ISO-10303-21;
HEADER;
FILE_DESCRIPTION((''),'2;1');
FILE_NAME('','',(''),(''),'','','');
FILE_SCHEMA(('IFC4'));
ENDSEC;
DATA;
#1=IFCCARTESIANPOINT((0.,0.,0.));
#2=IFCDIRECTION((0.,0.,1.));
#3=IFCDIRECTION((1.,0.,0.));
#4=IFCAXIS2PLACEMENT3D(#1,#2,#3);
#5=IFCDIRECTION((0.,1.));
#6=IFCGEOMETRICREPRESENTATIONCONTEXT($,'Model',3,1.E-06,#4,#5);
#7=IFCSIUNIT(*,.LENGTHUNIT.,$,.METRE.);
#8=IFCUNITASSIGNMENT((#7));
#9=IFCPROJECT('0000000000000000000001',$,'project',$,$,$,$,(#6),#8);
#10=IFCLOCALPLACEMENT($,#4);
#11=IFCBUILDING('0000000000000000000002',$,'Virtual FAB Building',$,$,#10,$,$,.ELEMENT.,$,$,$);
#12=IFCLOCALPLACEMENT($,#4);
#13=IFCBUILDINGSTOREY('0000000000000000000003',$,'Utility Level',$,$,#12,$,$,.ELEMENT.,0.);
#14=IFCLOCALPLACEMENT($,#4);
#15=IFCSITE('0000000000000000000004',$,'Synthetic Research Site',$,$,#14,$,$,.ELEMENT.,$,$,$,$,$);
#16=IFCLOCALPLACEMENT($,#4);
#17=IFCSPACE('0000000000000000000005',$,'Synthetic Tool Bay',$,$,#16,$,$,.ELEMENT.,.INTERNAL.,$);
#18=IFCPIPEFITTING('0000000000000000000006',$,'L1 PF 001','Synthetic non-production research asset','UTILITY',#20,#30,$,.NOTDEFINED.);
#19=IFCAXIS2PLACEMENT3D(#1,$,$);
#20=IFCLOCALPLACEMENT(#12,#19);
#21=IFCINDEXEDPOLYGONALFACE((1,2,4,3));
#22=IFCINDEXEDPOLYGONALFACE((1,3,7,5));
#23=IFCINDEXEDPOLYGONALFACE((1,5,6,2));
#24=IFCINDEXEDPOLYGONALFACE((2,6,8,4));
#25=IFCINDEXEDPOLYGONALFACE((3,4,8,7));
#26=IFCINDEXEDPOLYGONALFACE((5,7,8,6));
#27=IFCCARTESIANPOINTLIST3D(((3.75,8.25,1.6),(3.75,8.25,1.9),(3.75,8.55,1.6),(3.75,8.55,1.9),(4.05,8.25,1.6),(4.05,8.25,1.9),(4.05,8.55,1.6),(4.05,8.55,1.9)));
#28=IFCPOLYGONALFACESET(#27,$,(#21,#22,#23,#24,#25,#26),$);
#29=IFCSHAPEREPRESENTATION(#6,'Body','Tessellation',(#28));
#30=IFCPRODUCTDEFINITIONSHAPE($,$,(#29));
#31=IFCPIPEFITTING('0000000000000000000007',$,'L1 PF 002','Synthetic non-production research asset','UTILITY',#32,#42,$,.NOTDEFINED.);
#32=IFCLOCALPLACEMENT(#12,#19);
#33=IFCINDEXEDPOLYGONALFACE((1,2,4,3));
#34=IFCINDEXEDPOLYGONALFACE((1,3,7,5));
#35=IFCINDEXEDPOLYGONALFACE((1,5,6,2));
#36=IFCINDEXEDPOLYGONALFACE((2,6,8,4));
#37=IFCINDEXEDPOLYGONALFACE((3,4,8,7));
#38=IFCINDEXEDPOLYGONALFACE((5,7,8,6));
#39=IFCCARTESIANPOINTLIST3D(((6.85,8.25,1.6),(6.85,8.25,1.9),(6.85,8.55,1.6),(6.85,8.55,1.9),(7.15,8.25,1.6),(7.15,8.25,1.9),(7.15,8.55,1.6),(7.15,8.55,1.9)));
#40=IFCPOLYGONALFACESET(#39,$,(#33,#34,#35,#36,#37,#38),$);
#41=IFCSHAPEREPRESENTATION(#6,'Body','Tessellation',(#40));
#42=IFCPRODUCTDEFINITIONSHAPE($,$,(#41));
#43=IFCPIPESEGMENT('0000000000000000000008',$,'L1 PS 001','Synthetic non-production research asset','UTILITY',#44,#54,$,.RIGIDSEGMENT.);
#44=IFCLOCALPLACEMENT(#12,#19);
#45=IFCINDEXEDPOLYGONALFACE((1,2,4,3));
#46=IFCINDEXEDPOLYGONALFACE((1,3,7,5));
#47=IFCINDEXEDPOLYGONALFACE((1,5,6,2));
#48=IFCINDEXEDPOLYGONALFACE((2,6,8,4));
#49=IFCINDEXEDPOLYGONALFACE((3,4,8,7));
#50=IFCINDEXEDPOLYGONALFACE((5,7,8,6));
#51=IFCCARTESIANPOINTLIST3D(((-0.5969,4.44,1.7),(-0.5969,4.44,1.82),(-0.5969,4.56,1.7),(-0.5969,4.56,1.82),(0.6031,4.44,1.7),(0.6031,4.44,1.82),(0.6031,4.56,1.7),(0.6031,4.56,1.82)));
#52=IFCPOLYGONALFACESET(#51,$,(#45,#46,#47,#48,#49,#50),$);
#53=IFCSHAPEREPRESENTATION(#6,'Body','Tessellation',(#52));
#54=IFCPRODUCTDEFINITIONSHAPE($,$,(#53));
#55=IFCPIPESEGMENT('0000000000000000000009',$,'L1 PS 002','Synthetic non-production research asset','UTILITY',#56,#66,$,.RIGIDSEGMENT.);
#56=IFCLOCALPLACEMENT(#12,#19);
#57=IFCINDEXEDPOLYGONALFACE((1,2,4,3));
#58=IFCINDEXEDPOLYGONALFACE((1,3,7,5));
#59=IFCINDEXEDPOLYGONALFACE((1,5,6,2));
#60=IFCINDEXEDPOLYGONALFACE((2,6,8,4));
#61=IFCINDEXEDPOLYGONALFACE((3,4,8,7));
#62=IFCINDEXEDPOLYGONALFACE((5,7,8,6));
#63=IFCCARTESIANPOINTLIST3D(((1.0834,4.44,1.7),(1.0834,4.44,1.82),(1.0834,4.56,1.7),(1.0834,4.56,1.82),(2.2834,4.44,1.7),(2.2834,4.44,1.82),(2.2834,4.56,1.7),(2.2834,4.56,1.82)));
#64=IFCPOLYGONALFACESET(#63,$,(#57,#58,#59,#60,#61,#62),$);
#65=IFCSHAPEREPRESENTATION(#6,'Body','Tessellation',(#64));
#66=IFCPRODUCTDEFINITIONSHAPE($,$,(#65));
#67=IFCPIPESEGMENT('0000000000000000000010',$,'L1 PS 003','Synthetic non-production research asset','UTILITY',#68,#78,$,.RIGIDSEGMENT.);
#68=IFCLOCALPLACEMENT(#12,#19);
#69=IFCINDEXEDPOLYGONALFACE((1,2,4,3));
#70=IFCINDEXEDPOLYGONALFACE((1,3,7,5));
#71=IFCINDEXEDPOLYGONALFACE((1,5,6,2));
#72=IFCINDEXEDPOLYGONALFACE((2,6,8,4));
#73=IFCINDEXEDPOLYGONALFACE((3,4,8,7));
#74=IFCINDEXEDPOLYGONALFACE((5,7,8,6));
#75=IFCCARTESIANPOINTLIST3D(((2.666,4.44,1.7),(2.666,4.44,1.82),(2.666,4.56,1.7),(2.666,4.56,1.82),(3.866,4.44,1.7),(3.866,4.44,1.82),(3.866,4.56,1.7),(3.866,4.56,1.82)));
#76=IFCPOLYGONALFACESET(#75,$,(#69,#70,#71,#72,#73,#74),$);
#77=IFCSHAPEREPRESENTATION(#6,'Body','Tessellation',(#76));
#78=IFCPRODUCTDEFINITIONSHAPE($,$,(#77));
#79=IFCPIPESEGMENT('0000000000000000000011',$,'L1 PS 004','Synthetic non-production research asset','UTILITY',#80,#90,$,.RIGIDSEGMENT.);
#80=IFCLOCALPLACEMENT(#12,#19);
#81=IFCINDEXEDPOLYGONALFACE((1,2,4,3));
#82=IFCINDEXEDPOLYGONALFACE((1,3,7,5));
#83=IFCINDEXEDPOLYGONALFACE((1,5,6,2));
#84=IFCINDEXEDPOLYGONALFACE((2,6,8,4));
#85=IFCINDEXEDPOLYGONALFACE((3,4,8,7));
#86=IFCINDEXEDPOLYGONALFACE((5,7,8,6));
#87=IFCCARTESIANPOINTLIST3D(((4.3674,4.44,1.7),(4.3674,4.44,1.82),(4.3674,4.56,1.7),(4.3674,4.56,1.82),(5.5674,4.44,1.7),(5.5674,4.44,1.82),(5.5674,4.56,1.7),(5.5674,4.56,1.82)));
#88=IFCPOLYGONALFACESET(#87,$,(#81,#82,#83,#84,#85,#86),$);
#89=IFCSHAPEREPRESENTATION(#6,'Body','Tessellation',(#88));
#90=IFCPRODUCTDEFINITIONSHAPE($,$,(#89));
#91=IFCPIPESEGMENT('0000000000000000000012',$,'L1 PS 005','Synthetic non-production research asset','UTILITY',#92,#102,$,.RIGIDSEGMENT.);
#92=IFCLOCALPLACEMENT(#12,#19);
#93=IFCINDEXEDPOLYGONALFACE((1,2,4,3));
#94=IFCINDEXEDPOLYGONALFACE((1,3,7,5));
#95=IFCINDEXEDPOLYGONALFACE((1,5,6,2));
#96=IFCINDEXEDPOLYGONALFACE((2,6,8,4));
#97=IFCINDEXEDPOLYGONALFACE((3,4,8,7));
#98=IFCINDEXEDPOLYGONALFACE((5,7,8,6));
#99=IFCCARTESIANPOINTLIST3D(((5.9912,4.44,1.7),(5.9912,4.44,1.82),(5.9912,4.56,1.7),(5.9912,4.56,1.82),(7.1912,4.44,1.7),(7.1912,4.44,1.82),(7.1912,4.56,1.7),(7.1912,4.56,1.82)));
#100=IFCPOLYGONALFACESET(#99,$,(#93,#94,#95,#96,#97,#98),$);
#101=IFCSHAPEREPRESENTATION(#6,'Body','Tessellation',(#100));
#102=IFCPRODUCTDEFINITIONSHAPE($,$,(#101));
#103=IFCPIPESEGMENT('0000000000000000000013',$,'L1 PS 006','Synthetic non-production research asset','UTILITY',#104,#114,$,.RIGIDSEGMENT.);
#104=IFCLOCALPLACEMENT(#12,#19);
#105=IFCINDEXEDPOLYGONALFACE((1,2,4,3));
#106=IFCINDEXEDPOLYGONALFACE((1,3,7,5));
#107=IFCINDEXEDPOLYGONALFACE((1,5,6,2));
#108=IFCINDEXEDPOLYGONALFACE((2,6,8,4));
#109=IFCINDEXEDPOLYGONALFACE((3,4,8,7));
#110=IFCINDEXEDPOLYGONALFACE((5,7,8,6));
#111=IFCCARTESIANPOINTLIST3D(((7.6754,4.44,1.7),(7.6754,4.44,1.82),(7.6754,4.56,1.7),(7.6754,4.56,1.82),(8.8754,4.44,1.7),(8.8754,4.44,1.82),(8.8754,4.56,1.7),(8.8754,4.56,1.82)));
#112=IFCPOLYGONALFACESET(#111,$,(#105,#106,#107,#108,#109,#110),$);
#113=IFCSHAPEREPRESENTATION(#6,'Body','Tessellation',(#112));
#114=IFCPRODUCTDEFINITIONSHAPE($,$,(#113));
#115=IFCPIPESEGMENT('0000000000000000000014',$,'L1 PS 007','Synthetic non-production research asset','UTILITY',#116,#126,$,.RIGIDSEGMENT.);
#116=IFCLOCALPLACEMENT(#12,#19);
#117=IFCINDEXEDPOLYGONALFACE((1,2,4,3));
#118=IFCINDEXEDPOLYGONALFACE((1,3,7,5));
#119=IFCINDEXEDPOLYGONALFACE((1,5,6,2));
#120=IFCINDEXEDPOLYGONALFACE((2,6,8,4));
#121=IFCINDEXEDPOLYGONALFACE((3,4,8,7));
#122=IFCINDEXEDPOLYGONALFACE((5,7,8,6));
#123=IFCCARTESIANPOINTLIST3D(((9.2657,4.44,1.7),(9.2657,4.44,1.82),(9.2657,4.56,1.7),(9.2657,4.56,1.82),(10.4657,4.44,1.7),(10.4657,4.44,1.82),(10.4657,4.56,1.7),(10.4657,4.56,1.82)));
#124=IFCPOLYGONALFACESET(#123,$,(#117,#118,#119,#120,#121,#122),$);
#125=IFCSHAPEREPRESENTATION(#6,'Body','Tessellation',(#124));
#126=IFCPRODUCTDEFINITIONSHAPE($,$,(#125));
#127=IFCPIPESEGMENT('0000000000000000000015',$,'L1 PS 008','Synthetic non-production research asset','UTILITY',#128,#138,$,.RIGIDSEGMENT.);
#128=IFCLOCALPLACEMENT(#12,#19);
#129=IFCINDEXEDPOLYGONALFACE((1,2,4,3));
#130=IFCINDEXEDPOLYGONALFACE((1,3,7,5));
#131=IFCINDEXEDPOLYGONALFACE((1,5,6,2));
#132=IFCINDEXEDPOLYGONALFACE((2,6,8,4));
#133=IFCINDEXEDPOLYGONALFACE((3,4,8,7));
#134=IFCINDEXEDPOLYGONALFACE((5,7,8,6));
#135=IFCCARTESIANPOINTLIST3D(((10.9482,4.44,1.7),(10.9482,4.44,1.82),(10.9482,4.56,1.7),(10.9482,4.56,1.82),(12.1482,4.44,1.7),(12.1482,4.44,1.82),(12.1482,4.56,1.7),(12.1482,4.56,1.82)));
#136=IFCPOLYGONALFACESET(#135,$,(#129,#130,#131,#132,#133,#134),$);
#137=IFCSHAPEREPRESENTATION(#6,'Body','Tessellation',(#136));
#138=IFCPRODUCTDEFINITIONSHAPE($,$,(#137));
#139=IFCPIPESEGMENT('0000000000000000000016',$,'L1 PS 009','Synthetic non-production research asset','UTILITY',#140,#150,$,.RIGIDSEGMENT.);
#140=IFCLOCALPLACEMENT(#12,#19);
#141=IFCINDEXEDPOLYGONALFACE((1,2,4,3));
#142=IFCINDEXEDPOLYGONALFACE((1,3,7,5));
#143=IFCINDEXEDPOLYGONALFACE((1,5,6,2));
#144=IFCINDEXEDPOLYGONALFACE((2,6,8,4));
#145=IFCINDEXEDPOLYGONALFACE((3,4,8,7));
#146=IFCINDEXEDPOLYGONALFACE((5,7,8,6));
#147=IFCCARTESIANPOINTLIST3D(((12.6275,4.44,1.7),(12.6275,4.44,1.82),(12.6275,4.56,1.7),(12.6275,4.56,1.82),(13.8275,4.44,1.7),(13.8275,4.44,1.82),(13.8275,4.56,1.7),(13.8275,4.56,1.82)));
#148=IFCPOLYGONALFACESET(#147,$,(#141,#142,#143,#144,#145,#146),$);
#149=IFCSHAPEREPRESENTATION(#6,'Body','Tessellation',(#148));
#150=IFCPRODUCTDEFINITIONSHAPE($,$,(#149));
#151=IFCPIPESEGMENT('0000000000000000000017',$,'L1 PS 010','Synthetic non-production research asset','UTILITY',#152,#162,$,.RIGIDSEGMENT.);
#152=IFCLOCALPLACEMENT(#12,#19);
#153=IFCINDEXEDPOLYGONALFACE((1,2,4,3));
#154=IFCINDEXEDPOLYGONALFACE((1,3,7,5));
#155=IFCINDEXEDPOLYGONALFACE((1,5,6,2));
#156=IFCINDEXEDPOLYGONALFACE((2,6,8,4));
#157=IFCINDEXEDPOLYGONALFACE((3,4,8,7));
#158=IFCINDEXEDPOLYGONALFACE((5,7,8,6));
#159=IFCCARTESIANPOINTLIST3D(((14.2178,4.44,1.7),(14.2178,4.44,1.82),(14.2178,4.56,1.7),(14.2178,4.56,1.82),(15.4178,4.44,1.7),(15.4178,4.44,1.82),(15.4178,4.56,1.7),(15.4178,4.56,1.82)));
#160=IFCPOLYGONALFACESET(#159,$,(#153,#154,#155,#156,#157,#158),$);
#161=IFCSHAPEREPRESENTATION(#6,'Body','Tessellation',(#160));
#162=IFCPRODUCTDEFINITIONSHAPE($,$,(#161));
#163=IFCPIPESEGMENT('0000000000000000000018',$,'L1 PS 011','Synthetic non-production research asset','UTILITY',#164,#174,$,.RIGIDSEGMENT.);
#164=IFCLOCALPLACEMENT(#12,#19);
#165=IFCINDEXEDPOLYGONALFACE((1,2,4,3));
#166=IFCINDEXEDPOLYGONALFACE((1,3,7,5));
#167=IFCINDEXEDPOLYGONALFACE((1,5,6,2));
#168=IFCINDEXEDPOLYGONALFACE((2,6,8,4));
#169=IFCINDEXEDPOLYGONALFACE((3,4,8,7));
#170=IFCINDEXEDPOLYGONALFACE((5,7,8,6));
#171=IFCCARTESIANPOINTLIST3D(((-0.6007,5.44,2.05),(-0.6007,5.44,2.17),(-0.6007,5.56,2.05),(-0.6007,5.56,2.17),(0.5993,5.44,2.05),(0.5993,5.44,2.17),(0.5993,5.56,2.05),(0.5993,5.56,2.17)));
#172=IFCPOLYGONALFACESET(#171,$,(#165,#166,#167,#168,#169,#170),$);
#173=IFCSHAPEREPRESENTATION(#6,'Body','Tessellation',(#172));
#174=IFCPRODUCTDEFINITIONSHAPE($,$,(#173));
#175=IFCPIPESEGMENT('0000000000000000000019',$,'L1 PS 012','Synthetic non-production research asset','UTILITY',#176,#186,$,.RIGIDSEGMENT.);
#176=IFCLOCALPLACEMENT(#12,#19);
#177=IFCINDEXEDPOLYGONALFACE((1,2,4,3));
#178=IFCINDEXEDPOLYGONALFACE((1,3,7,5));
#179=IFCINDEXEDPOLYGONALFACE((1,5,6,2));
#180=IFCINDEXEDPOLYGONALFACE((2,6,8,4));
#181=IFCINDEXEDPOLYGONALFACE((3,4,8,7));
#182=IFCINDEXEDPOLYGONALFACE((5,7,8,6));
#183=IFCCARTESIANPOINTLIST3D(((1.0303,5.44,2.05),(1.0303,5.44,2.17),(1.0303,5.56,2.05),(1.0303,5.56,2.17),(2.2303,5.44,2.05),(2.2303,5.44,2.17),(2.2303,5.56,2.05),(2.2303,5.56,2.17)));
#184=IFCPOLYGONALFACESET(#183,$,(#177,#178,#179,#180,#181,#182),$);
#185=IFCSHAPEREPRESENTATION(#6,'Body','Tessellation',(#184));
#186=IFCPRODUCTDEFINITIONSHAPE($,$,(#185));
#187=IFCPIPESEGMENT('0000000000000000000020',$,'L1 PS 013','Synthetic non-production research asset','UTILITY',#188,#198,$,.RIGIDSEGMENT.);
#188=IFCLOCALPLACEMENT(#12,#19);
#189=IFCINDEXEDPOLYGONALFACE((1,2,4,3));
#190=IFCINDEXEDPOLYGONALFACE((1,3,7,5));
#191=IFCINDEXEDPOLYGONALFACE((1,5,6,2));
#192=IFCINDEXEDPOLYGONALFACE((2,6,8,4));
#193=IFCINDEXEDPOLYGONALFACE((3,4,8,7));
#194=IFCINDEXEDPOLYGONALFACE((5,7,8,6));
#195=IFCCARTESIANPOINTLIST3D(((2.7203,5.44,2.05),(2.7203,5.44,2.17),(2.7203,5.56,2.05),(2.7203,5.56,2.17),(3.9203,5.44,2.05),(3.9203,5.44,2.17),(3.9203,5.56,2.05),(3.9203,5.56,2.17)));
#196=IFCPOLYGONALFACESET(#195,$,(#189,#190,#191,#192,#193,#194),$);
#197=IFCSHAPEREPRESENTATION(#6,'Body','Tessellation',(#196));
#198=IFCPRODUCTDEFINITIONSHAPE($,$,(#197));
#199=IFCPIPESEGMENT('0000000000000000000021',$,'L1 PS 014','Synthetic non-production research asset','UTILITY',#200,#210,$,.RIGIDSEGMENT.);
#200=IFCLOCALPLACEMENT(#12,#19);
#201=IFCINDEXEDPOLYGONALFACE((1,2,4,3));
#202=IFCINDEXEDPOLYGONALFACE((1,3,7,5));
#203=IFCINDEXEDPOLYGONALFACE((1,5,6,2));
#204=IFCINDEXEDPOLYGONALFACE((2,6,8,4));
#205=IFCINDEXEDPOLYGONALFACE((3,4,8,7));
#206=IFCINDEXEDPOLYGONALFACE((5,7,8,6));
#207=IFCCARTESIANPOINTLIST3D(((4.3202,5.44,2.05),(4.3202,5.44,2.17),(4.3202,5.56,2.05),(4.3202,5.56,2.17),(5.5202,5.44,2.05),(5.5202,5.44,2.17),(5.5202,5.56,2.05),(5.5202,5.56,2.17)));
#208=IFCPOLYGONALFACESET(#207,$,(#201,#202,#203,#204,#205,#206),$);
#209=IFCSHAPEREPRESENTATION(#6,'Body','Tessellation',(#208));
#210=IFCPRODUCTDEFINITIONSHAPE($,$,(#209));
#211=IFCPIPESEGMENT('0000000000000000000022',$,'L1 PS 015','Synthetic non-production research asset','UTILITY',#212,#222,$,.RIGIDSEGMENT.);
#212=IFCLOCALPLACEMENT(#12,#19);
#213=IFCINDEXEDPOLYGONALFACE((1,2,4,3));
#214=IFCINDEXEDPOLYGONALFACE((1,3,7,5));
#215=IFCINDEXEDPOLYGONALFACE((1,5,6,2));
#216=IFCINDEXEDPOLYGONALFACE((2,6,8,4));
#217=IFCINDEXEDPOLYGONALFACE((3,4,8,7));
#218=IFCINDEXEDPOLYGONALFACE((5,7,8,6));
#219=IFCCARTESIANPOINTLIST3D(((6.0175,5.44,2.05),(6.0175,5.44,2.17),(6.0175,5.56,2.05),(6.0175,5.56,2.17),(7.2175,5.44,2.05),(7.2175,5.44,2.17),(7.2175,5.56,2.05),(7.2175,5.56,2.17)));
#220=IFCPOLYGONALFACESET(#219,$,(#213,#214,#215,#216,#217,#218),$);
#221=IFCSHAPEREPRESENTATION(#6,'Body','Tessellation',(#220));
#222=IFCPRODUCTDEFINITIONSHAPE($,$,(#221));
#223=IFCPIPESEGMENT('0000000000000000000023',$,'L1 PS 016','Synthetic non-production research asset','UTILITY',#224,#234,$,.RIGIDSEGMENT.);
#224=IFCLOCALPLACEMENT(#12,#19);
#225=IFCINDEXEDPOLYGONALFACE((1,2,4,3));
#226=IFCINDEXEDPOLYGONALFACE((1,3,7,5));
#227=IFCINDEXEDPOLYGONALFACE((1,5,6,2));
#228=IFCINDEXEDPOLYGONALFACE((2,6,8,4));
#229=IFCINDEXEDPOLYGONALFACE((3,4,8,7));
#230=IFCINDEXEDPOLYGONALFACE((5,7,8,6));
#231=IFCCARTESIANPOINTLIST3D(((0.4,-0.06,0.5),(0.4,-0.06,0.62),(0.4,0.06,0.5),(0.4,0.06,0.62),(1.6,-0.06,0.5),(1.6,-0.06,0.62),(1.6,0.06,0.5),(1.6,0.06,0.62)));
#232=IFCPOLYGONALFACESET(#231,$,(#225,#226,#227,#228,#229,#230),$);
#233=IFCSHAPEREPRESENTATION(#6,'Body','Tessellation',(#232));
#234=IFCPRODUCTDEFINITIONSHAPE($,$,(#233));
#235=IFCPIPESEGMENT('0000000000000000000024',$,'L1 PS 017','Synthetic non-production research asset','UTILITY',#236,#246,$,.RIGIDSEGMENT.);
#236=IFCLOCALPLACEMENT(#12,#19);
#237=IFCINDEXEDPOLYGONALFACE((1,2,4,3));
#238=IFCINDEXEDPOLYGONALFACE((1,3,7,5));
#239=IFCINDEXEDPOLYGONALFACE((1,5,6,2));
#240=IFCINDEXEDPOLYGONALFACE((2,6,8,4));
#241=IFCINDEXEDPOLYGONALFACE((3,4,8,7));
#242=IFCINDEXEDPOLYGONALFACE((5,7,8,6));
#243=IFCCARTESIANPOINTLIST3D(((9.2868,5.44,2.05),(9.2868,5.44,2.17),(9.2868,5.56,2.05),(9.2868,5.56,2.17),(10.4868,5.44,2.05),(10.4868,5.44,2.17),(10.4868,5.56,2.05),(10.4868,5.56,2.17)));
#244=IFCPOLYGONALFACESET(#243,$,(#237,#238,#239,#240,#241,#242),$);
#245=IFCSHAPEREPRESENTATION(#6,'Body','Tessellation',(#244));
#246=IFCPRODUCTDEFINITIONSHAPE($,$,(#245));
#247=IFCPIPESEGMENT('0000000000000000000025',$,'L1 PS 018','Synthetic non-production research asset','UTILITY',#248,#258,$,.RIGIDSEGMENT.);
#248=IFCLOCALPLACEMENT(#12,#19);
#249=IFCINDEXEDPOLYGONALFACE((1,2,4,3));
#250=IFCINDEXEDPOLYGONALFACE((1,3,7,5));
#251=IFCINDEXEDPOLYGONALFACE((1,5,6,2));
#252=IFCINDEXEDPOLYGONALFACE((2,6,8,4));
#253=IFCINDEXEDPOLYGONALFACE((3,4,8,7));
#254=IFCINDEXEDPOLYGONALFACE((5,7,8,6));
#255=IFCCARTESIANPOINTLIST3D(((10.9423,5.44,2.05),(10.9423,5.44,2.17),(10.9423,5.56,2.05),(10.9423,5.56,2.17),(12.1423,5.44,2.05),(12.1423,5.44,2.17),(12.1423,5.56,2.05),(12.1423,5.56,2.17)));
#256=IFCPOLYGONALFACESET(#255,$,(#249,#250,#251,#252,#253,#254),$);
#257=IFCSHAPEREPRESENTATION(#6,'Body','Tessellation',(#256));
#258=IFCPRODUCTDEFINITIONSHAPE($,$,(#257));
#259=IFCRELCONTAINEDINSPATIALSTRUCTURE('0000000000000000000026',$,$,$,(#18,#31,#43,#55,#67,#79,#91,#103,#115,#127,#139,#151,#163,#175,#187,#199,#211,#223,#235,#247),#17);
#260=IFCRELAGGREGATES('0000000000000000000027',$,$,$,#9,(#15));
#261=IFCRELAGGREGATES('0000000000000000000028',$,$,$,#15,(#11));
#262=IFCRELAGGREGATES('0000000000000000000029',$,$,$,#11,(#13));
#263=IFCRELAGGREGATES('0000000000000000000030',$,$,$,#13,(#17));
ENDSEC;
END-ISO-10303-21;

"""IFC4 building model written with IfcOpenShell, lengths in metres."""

from ifc_helpers import new_model, si_unit, direction, frame, origin_with_axes, origin_2d_with_axis, place, context, project, spatial, rectangle, extrude, element, save


model = new_model("IFC4")

# Units and contexts
model_context = context("Model", 3, precision=1e-06, world=origin_with_axes(), true_north=direction((0.0, 1.0)))
ifc_project = project(units=[si_unit("LENGTHUNIT", "METRE")], contexts=[model_context])

# Site, building, storey, space
site_placement = place(None, origin_with_axes())
site = spatial("IfcSite", under=ifc_project, at=site_placement, Name="Synthetic Research Site", CompositionType="ELEMENT")
building_placement = place(None, origin_with_axes())
building = spatial("IfcBuilding", under=site, at=building_placement, Name="Virtual FAB Building", CompositionType="ELEMENT")
storey_placement = place(None, origin_with_axes())
storey = spatial("IfcBuildingStorey", under=building, at=storey_placement, Name="Utility Level", CompositionType="ELEMENT", Elevation=0.0)
space_placement = place(None, origin_with_axes())
space = spatial("IfcSpace", under=storey, at=space_placement, Name="Synthetic Tool Bay", CompositionType="ELEMENT", PredefinedType="INTERNAL")

# Pipe fittings
for number, where, z_axis, x_axis, name in (
    (1, (3.9, 8.4, 1.6), (0.0, 0.0, 1.0), (1.0, 0.0, 0.0), "L1 PF 001"),
    (2, (7.0, 8.4, 1.6), (0.0, 0.0, 1.0), (1.0, 0.0, 0.0), "L1 PF 002"),
):
    element("IfcPipeFitting", number, at=place(None, frame(where, z_axis=z_axis, x_axis=x_axis)), inside=space, Name=name, Description="Synthetic non-production research asset", ObjectType="UTILITY", PredefinedType="NOTDEFINED", context=model_context, shape_type="SweptSolid", body=[
        extrude(rectangle(XDim=0.3, YDim=0.3, at=origin_2d_with_axis()), origin_with_axes(), (0.0, 0.0, 1.0), 0.3),
    ])

# Pipe segments
for number, where, z_axis, x_axis, name in (
    (3, (0.0031, 4.5, 1.7), (0.0, 0.0, 1.0), (1.0, 0.0, 0.0), "L1 PS 001"),
    (4, (1.6834, 4.5, 1.7), (0.0, 0.0, 1.0), (1.0, 0.0, 0.0), "L1 PS 002"),
    (5, (3.266, 4.5, 1.7), (0.0, 0.0, 1.0), (1.0, 0.0, 0.0), "L1 PS 003"),
    (6, (4.9674, 4.5, 1.7), (0.0, 0.0, 1.0), (1.0, 0.0, 0.0), "L1 PS 004"),
    (7, (6.5912, 4.5, 1.7), (0.0, 0.0, 1.0), (1.0, 0.0, 0.0), "L1 PS 005"),
    (8, (8.2754, 4.5, 1.7), (0.0, 0.0, 1.0), (1.0, 0.0, 0.0), "L1 PS 006"),
    (9, (9.8657, 4.5, 1.7), (0.0, 0.0, 1.0), (1.0, 0.0, 0.0), "L1 PS 007"),
    (10, (11.5482, 4.5, 1.7), (0.0, 0.0, 1.0), (1.0, 0.0, 0.0), "L1 PS 008"),
    (11, (13.2275, 4.5, 1.7), (0.0, 0.0, 1.0), (1.0, 0.0, 0.0), "L1 PS 009"),
    (12, (14.8178, 4.5, 1.7), (0.0, 0.0, 1.0), (1.0, 0.0, 0.0), "L1 PS 010"),
    (13, (-0.0007, 5.5, 2.05), (0.0, 0.0, 1.0), (1.0, 0.0, 0.0), "L1 PS 011"),
    (14, (1.6303, 5.5, 2.05), (0.0, 0.0, 1.0), (1.0, 0.0, 0.0), "L1 PS 012"),
    (15, (3.3203, 5.5, 2.05), (0.0, 0.0, 1.0), (1.0, 0.0, 0.0), "L1 PS 013"),
    (16, (4.9202, 5.5, 2.05), (0.0, 0.0, 1.0), (1.0, 0.0, 0.0), "L1 PS 014"),
    (17, (6.6175, 5.5, 2.05), (0.0, 0.0, 1.0), (1.0, 0.0, 0.0), "L1 PS 015"),
    (18, (1.0, 0.0, 0.5), (0.0, 0.0, 1.0), (1.0, 0.0, 0.0), "L1 PS 016"),
    (19, (9.8868, 5.5, 2.05), (0.0, 0.0, 1.0), (1.0, 0.0, 0.0), "L1 PS 017"),
    (20, (11.5423, 5.5, 2.05), (0.0, 0.0, 1.0), (1.0, 0.0, 0.0), "L1 PS 018"),
):
    element("IfcPipeSegment", number, at=place(None, frame(where, z_axis=z_axis, x_axis=x_axis)), inside=space, Name=name, Description="Synthetic non-production research asset", ObjectType="UTILITY", PredefinedType="RIGIDSEGMENT", context=model_context, shape_type="SweptSolid", body=[
        extrude(rectangle(XDim=1.2, YDim=0.12, at=origin_2d_with_axis()), origin_with_axes(), (0.0, 0.0, 1.0), 0.12),
    ])

save(model, "model.ifc")
